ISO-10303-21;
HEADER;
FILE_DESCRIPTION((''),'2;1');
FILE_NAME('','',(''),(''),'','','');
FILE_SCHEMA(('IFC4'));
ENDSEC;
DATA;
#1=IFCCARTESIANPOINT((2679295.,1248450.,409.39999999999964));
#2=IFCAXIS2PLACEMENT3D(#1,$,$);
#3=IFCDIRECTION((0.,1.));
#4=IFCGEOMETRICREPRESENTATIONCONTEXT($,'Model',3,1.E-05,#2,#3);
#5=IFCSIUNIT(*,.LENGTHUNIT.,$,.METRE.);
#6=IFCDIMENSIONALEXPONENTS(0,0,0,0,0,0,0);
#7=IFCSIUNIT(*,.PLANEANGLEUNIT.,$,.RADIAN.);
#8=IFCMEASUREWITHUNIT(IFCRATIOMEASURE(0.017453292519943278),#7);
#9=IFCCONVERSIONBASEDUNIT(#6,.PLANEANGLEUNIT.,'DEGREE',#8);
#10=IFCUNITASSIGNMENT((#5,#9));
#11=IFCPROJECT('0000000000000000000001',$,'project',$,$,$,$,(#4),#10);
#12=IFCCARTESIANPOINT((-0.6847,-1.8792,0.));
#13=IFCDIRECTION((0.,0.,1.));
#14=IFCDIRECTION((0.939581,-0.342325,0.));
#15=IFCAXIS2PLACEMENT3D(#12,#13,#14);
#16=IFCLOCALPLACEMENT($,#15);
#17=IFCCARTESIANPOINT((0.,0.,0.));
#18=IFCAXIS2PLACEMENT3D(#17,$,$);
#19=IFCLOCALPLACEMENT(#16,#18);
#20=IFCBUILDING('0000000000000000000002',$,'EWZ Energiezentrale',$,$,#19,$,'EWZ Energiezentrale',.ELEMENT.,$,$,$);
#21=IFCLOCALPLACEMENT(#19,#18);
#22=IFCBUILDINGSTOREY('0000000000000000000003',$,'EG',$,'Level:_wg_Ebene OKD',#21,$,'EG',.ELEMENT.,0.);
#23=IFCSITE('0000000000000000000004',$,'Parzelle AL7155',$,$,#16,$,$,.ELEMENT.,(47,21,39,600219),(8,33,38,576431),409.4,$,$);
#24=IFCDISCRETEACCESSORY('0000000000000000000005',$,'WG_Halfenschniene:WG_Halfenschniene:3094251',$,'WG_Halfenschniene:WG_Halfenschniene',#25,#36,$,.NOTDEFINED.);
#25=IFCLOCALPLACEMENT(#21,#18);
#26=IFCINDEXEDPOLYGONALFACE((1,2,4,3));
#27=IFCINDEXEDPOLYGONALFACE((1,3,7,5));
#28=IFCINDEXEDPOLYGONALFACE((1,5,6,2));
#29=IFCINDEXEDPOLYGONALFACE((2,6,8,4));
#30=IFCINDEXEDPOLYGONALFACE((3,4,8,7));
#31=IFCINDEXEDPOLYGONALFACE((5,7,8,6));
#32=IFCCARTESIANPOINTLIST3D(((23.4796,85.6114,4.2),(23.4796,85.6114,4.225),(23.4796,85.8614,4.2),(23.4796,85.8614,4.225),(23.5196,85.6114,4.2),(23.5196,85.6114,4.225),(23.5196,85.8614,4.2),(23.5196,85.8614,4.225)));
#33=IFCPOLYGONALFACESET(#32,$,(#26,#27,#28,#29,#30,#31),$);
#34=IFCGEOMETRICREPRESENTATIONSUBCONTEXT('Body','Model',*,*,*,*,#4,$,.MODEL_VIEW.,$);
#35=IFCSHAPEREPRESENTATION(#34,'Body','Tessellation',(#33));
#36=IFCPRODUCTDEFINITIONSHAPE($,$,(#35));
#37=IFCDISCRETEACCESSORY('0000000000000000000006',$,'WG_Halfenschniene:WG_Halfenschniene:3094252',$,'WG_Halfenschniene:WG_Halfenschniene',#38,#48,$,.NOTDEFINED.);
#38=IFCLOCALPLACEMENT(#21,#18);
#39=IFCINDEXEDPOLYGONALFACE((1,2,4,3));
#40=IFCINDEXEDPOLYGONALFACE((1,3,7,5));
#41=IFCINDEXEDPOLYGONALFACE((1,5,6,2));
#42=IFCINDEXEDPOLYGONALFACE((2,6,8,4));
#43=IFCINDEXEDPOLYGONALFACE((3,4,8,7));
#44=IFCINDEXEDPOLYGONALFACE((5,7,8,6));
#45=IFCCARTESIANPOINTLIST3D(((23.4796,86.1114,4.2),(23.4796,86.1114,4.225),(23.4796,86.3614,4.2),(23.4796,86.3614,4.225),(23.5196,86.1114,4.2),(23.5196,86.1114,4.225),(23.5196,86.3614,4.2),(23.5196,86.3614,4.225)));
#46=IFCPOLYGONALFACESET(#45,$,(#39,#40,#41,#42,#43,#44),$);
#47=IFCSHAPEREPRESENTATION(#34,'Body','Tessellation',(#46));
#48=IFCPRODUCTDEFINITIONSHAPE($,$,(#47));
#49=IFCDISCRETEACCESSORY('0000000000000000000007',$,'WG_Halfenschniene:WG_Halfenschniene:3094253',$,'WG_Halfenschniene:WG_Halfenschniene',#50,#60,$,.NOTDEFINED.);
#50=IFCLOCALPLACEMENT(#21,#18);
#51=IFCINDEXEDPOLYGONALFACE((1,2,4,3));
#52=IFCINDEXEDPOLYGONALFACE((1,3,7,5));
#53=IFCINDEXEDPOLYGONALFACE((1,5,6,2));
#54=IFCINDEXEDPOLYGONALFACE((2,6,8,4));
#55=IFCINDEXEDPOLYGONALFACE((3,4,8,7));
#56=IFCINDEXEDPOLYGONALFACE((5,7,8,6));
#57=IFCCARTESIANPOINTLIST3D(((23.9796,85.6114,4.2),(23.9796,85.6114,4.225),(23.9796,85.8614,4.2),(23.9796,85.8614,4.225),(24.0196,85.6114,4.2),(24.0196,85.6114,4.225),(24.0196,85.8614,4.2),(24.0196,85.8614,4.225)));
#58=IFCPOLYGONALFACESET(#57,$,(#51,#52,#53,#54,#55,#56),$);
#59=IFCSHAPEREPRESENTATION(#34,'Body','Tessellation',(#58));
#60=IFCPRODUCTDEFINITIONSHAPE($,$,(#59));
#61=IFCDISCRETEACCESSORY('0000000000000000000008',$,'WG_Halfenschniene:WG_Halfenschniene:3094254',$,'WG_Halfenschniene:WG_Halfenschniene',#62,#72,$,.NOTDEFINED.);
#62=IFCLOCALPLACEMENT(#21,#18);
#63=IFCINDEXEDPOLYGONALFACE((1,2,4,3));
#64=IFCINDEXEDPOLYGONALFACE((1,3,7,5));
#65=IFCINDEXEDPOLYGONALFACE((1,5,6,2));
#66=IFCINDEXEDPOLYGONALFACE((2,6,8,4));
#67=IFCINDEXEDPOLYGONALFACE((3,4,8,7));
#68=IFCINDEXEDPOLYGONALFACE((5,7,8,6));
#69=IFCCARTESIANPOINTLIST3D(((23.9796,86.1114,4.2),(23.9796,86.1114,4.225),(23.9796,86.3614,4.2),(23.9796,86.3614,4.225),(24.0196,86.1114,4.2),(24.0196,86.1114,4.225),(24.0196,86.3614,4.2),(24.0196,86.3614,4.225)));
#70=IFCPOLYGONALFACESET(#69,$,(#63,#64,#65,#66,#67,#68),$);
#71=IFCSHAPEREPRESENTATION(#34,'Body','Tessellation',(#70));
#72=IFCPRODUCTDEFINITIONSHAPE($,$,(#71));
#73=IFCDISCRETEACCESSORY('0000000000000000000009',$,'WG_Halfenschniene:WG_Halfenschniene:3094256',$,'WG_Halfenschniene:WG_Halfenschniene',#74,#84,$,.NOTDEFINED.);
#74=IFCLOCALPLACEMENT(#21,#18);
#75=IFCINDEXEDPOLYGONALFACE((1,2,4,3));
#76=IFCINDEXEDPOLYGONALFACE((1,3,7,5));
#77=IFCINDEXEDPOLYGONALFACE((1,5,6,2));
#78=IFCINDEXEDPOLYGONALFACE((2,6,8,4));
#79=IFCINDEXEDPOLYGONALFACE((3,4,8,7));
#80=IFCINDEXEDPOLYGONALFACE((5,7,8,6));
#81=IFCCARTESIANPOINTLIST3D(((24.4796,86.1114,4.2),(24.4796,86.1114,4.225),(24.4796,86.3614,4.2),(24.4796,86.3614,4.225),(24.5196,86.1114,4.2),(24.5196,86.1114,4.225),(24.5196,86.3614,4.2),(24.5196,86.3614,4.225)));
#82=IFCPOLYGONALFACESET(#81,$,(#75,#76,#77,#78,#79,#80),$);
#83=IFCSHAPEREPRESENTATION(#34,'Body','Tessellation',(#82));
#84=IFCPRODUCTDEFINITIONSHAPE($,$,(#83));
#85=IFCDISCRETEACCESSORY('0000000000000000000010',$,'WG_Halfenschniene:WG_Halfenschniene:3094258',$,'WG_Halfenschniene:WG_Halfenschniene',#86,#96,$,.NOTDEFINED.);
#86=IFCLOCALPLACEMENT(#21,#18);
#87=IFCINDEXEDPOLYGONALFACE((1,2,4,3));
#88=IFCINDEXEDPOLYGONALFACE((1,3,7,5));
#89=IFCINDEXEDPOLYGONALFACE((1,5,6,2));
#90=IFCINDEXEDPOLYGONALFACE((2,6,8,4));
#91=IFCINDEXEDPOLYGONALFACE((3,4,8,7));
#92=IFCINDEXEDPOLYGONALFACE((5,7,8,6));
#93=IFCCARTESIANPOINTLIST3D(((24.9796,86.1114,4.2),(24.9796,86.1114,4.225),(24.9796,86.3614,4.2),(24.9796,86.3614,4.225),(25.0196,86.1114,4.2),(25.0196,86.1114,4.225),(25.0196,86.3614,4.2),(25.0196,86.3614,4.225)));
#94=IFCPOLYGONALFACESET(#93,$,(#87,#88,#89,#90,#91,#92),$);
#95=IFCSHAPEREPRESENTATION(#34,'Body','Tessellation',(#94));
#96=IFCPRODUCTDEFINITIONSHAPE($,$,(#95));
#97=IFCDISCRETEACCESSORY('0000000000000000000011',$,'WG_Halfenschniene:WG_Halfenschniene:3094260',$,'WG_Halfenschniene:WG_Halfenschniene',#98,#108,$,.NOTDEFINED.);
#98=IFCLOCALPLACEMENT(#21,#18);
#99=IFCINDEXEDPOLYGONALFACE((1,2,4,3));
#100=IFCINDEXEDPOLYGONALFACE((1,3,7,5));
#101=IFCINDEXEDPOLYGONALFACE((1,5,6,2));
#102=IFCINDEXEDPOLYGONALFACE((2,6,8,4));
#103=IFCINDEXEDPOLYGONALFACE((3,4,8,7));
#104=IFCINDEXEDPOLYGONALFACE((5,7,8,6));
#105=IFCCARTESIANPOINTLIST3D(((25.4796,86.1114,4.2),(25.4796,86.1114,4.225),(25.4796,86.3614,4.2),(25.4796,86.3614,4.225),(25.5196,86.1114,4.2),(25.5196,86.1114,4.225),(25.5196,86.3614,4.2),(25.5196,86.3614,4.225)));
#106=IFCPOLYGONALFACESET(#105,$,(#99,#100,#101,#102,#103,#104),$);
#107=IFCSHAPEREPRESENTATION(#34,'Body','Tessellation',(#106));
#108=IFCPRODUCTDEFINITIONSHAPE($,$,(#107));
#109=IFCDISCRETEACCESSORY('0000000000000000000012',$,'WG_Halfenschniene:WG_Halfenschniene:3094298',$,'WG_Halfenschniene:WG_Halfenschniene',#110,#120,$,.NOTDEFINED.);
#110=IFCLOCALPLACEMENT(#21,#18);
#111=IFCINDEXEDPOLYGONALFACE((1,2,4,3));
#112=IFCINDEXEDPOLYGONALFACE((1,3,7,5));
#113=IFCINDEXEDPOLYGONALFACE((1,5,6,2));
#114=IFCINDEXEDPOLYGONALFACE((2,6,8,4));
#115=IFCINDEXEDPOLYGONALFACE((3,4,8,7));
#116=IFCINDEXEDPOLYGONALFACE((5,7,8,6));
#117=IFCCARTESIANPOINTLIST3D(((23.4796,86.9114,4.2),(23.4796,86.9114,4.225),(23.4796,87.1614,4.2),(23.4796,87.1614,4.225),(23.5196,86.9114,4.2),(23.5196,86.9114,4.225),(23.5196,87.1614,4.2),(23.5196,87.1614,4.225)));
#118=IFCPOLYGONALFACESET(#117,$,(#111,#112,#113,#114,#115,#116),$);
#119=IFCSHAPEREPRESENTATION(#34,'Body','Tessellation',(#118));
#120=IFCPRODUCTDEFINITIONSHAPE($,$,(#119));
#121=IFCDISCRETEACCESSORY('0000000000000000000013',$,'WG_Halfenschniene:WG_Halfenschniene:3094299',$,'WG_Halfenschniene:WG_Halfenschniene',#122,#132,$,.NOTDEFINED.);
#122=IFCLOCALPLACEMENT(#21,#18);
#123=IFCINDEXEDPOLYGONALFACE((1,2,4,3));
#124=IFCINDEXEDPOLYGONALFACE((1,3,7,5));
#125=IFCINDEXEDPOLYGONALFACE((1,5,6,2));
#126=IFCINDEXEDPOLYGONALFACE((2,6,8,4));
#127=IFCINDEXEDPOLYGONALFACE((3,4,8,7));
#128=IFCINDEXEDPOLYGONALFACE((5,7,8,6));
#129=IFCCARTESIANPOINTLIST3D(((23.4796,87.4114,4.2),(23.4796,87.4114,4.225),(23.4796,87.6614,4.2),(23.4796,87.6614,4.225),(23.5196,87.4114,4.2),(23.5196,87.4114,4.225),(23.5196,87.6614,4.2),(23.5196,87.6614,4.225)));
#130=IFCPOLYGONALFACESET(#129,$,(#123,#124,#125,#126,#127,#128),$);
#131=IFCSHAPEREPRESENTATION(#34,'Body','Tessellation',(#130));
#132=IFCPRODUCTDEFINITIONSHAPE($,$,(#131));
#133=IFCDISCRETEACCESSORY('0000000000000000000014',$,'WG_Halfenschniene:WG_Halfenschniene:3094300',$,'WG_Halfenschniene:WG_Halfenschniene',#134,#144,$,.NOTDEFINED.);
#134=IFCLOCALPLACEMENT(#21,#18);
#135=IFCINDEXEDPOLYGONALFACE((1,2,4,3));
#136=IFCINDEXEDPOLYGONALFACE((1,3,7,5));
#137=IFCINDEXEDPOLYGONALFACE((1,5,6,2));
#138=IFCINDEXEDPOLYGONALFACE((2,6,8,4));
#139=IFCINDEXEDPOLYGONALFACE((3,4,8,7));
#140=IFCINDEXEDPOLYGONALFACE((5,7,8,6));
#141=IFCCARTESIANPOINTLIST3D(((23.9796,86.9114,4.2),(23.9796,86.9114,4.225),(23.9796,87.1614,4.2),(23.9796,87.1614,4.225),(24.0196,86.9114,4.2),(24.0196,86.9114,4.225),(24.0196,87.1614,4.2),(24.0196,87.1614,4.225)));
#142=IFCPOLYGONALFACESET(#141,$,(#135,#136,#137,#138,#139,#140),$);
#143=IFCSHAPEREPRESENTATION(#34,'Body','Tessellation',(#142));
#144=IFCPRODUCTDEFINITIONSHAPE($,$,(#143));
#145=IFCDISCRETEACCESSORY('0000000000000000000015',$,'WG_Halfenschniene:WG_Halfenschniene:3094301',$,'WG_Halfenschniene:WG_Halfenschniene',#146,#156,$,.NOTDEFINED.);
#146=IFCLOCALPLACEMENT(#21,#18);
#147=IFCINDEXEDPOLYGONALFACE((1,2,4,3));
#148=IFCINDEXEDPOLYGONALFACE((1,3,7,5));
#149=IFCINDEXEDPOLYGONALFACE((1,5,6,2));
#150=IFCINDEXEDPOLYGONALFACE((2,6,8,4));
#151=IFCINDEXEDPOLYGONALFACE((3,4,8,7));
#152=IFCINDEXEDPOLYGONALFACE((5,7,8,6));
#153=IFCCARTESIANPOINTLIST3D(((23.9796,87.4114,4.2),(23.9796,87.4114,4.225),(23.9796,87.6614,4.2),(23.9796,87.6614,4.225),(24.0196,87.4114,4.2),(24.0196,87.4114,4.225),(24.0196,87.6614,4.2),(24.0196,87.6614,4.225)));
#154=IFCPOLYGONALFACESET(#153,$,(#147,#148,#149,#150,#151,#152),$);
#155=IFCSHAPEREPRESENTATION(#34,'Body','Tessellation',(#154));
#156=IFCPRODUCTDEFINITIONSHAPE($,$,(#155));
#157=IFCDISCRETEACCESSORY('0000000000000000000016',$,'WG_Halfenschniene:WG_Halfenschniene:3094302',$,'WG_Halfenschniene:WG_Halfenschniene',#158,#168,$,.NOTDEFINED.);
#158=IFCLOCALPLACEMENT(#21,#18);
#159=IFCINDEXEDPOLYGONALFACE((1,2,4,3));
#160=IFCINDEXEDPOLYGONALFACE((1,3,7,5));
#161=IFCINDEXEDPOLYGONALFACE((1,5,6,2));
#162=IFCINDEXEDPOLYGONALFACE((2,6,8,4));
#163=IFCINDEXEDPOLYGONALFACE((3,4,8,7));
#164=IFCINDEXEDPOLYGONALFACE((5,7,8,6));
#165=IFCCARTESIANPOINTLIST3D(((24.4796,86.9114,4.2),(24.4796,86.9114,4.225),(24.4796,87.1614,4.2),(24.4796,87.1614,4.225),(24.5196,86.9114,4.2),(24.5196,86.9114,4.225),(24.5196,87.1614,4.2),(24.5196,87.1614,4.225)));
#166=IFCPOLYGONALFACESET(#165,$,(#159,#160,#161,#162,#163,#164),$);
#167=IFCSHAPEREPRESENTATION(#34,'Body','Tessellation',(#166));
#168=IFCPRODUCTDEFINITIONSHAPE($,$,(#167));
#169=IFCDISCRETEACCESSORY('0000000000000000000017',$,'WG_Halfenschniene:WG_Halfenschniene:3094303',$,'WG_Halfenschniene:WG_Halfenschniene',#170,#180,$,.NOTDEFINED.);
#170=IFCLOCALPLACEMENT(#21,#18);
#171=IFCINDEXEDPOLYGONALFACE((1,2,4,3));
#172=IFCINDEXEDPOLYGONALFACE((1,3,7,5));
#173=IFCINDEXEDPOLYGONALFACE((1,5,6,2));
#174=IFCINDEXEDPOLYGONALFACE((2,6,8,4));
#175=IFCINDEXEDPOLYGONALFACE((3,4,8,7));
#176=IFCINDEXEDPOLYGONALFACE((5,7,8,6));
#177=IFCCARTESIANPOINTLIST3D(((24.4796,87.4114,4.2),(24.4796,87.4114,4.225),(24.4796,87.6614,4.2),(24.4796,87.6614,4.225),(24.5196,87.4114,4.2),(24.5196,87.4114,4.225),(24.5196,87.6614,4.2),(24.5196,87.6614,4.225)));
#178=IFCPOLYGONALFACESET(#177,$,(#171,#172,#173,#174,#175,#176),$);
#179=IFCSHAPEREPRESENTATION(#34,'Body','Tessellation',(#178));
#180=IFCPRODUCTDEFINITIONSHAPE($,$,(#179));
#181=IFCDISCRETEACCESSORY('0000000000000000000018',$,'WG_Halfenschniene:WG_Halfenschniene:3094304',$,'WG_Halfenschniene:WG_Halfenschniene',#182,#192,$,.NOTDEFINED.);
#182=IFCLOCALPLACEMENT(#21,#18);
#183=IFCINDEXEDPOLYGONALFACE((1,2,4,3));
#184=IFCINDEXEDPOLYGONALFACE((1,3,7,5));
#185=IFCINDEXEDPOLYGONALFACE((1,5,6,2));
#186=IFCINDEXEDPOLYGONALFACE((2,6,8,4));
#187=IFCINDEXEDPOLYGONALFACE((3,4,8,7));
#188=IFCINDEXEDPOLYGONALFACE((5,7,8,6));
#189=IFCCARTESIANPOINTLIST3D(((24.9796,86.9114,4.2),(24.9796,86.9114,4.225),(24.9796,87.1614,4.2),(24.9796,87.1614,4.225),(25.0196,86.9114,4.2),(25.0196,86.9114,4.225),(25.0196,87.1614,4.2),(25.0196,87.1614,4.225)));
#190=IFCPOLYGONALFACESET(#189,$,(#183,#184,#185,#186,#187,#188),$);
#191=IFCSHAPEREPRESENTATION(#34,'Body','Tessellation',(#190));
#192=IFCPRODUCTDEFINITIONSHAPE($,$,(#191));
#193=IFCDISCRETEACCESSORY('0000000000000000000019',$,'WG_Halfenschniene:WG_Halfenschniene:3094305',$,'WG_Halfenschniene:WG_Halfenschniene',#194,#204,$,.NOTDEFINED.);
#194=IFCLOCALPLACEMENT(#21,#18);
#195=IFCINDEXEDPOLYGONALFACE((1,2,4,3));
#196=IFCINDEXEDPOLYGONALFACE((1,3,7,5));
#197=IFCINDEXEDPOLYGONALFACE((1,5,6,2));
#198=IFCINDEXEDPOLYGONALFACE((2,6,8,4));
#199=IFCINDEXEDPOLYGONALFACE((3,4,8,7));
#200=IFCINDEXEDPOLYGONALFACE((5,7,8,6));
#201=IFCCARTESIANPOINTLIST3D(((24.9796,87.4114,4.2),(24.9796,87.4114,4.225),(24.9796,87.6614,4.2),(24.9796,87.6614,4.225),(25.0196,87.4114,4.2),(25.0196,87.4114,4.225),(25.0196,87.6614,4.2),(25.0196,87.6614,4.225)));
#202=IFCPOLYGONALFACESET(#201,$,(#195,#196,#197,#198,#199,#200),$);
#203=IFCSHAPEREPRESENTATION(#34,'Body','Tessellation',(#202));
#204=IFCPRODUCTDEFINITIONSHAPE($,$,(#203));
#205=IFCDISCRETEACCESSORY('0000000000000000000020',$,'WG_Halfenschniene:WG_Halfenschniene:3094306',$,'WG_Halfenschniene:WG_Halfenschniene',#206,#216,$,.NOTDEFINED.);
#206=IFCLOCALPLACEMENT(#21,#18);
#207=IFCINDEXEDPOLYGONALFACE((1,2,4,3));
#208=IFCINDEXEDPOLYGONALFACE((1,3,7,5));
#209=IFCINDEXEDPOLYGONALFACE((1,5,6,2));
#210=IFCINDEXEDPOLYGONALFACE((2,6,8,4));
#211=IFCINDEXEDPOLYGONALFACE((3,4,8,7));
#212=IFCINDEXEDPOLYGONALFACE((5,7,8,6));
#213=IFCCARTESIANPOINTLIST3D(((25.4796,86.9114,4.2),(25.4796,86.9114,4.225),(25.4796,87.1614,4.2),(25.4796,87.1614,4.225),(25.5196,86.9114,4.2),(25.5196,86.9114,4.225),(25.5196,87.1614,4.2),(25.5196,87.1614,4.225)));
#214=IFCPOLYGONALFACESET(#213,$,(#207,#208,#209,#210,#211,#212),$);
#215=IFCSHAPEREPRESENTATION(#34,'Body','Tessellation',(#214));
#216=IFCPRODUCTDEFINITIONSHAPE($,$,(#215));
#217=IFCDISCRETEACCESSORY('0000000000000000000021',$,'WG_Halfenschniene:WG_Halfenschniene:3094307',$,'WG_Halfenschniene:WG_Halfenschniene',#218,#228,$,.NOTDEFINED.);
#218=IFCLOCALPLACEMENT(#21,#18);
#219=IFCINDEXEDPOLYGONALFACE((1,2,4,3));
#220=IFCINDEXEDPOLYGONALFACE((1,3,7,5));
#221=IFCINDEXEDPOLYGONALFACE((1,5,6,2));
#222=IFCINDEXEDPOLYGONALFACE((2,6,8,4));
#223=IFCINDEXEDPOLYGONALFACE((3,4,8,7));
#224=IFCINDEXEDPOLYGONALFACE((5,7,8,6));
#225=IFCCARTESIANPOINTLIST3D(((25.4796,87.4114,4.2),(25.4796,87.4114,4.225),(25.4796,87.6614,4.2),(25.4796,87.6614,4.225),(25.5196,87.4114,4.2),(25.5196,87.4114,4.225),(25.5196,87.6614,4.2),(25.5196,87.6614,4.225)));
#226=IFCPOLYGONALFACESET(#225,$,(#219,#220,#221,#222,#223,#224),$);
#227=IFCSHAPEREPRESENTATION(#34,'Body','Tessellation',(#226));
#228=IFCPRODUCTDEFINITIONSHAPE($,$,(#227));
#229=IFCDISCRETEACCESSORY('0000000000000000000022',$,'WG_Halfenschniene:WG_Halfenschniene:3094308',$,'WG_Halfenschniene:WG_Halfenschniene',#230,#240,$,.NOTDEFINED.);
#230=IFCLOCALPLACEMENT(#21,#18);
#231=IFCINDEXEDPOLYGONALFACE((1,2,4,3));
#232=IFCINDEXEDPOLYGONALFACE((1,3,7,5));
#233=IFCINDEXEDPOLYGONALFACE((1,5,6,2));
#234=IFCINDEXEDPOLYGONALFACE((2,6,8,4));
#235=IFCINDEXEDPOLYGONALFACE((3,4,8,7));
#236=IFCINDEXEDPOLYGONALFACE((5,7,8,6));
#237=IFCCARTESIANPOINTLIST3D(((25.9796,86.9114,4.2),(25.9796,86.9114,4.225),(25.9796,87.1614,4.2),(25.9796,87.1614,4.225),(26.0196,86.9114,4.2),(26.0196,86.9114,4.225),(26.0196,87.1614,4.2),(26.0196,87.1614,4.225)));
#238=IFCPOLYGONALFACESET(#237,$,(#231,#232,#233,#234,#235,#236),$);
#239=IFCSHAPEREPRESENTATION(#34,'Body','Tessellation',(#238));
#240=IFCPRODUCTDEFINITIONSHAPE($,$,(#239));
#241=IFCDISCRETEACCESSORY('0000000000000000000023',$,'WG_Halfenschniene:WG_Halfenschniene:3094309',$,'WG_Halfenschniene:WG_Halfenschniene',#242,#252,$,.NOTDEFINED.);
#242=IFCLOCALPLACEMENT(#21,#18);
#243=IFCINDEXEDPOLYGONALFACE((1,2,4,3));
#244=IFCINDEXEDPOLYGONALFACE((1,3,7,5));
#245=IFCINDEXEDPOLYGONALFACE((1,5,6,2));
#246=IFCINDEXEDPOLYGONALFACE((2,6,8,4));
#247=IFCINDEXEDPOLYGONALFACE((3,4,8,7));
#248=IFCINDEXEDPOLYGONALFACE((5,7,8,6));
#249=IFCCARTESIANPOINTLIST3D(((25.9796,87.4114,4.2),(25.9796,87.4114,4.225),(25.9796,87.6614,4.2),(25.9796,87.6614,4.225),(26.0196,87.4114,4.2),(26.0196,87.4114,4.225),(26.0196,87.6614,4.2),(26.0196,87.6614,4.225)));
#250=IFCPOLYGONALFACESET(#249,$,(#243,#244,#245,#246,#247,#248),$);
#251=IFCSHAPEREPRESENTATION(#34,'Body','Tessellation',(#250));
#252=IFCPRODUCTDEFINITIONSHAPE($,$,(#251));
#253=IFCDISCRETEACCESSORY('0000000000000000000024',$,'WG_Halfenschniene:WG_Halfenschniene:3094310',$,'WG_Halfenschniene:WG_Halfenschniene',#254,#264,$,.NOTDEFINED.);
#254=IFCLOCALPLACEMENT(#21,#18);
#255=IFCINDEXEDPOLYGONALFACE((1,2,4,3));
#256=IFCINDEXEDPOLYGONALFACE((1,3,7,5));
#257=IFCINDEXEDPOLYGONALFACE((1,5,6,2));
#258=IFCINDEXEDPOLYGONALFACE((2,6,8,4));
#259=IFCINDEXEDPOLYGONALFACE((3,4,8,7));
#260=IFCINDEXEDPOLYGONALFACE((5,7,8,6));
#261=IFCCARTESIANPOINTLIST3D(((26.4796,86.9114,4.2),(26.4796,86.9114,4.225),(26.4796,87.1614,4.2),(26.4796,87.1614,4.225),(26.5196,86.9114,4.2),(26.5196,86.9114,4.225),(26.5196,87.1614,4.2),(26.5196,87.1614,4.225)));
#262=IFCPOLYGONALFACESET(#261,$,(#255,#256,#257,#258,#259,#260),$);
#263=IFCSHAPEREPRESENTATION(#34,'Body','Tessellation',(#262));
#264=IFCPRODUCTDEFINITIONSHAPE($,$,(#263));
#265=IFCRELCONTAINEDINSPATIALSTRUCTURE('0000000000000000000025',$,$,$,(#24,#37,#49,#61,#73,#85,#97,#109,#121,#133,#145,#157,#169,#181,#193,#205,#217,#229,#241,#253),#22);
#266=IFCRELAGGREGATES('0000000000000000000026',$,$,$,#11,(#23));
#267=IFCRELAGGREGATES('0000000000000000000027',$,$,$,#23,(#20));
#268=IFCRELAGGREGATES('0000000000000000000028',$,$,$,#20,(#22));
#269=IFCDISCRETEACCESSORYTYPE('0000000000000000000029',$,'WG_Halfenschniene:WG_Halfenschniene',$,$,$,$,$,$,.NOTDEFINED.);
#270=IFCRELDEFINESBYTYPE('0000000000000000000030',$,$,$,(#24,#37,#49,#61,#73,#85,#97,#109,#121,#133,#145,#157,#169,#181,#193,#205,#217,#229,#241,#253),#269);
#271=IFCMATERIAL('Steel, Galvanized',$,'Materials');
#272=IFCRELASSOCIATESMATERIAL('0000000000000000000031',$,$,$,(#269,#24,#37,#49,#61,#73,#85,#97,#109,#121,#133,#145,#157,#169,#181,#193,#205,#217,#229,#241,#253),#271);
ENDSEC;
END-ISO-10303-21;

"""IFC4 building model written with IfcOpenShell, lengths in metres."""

from ifc_helpers import new_model, entity, si_unit, converted_unit, direction, frame, origin, place, context, subcontext, project, spatial, indexed_curve, outline, extrude, source, transform, mapped, material, type_object, element, save


model = new_model("IFC4")

# Units and contexts
model_context = context("Model", 3, precision=1e-05, world=frame((2679295.0, 1248450.0, 409.39999999999964)), true_north=direction((0.0, 1.0)))
body_context = subcontext(model_context, "Body", "Model", "MODEL_VIEW")
ifc_project = project(units=[si_unit("LENGTHUNIT", "METRE"), converted_unit("PLANEANGLEUNIT", "DEGREE", entity("IfcRatioMeasure", 0.017453292519943278), si_unit("PLANEANGLEUNIT", "RADIAN"), dimensions=[0, 0, 0, 0, 0, 0, 0])], contexts=[model_context])

# Site, building, storey
site_placement = place(None, frame((-0.6847, -1.8792, 0.0), z_axis=(0.0, 0.0, 1.0), x_axis=(0.939581, -0.342325, 0.0)))
site = spatial("IfcSite", under=ifc_project, at=site_placement, Name="Parzelle AL7155", CompositionType="ELEMENT", RefLatitude=(47, 21, 39, 600219), RefLongitude=(8, 33, 38, 576431), RefElevation=409.4)
building_placement = place(site_placement, origin())
building = spatial("IfcBuilding", under=site, at=building_placement, Name="EWZ Energiezentrale", LongName="EWZ Energiezentrale", CompositionType="ELEMENT")
storey_placement = place(building_placement, origin())
storey = spatial("IfcBuildingStorey", under=building, at=storey_placement, Name="EG", ObjectType="Level:_wg_Ebene OKD", LongName="EG", CompositionType="ELEMENT", Elevation=0.0)

# Discrete accessories
ifc_material = material(Name="Steel, Galvanized", Category="Materials")
discrete_accessory_type = type_object("IfcDiscreteAccessoryType", Name="WG_Halfenschniene:WG_Halfenschniene", PredefinedType="NOTDEFINED", material=ifc_material)
shared_shape = source(origin(), body_context, "Body", "SweptSolid", [
    extrude(outline(indexed_curve([(-0.125, -0.02), (0.125, -0.02), (0.125, 0.02), (-0.125, 0.02), (-0.125, -0.02)], self_intersect=False)), frame((0.125, 0.0, -0.0125)), (0.0, 0.0, 1.0), 0.025),
])
for number, where, z_axis, x_axis, name in (
    (1, (23.4996, 85.6114, 4.2125), (0.0, 0.0, -1.0), (0.0, 1.0, 0.0), "WG_Halfenschniene:WG_Halfenschniene:3094251"),
    (2, (23.4996, 86.1114, 4.2125), (0.0, 0.0, -1.0), (0.0, 1.0, 0.0), "WG_Halfenschniene:WG_Halfenschniene:3094252"),
    (3, (23.9996, 85.6114, 4.2125), (0.0, 0.0, -1.0), (0.0, 1.0, 0.0), "WG_Halfenschniene:WG_Halfenschniene:3094253"),
    (4, (23.9996, 86.1114, 4.2125), (0.0, 0.0, -1.0), (0.0, 1.0, 0.0), "WG_Halfenschniene:WG_Halfenschniene:3094254"),
    (5, (24.4996, 86.1114, 4.2125), (0.0, 0.0, -1.0), (0.0, 1.0, 0.0), "WG_Halfenschniene:WG_Halfenschniene:3094256"),
    (6, (24.9996, 86.1114, 4.2125), (0.0, 0.0, -1.0), (0.0, 1.0, 0.0), "WG_Halfenschniene:WG_Halfenschniene:3094258"),
    (7, (25.4996, 86.1114, 4.2125), (0.0, 0.0, -1.0), (0.0, 1.0, 0.0), "WG_Halfenschniene:WG_Halfenschniene:3094260"),
    (8, (23.4996, 86.9114, 4.2125), (0.0, 0.0, -1.0), (0.0, 1.0, 0.0), "WG_Halfenschniene:WG_Halfenschniene:3094298"),
    (9, (23.4996, 87.4114, 4.2125), (0.0, 0.0, -1.0), (0.0, 1.0, 0.0), "WG_Halfenschniene:WG_Halfenschniene:3094299"),
    (10, (23.9996, 86.9114, 4.2125), (0.0, 0.0, -1.0), (0.0, 1.0, 0.0), "WG_Halfenschniene:WG_Halfenschniene:3094300"),
    (11, (23.9996, 87.4114, 4.2125), (0.0, 0.0, -1.0), (0.0, 1.0, 0.0), "WG_Halfenschniene:WG_Halfenschniene:3094301"),
    (12, (24.4996, 86.9114, 4.2125), (0.0, 0.0, -1.0), (0.0, 1.0, 0.0), "WG_Halfenschniene:WG_Halfenschniene:3094302"),
    (13, (24.4996, 87.4114, 4.2125), (0.0, 0.0, -1.0), (0.0, 1.0, 0.0), "WG_Halfenschniene:WG_Halfenschniene:3094303"),
    (14, (24.9996, 86.9114, 4.2125), (0.0, 0.0, -1.0), (0.0, 1.0, 0.0), "WG_Halfenschniene:WG_Halfenschniene:3094304"),
    (15, (24.9996, 87.4114, 4.2125), (0.0, 0.0, -1.0), (0.0, 1.0, 0.0), "WG_Halfenschniene:WG_Halfenschniene:3094305"),
    (16, (25.4996, 86.9114, 4.2125), (0.0, 0.0, -1.0), (0.0, 1.0, 0.0), "WG_Halfenschniene:WG_Halfenschniene:3094306"),
    (17, (25.4996, 87.4114, 4.2125), (0.0, 0.0, -1.0), (0.0, 1.0, 0.0), "WG_Halfenschniene:WG_Halfenschniene:3094307"),
    (18, (25.9996, 86.9114, 4.2125), (0.0, 0.0, -1.0), (0.0, 1.0, 0.0), "WG_Halfenschniene:WG_Halfenschniene:3094308"),
    (19, (25.9996, 87.4114, 4.2125), (0.0, 0.0, -1.0), (0.0, 1.0, 0.0), "WG_Halfenschniene:WG_Halfenschniene:3094309"),
    (20, (26.4996, 86.9114, 4.2125), (0.0, 0.0, -1.0), (0.0, 1.0, 0.0), "WG_Halfenschniene:WG_Halfenschniene:3094310"),
):
    element("IfcDiscreteAccessory", number, at=place(storey_placement, frame(where, z_axis=z_axis, x_axis=x_axis)), inside=storey, type_object=discrete_accessory_type, material=ifc_material, Name=name, ObjectType="WG_Halfenschniene:WG_Halfenschniene", PredefinedType="NOTDEFINED", context=body_context, shape_type="MappedRepresentation", body=[
        mapped(shared_shape, transform((0.0, 0.0, 0.0), scale=1.0)),
    ])

save(model, "model.ifc")
